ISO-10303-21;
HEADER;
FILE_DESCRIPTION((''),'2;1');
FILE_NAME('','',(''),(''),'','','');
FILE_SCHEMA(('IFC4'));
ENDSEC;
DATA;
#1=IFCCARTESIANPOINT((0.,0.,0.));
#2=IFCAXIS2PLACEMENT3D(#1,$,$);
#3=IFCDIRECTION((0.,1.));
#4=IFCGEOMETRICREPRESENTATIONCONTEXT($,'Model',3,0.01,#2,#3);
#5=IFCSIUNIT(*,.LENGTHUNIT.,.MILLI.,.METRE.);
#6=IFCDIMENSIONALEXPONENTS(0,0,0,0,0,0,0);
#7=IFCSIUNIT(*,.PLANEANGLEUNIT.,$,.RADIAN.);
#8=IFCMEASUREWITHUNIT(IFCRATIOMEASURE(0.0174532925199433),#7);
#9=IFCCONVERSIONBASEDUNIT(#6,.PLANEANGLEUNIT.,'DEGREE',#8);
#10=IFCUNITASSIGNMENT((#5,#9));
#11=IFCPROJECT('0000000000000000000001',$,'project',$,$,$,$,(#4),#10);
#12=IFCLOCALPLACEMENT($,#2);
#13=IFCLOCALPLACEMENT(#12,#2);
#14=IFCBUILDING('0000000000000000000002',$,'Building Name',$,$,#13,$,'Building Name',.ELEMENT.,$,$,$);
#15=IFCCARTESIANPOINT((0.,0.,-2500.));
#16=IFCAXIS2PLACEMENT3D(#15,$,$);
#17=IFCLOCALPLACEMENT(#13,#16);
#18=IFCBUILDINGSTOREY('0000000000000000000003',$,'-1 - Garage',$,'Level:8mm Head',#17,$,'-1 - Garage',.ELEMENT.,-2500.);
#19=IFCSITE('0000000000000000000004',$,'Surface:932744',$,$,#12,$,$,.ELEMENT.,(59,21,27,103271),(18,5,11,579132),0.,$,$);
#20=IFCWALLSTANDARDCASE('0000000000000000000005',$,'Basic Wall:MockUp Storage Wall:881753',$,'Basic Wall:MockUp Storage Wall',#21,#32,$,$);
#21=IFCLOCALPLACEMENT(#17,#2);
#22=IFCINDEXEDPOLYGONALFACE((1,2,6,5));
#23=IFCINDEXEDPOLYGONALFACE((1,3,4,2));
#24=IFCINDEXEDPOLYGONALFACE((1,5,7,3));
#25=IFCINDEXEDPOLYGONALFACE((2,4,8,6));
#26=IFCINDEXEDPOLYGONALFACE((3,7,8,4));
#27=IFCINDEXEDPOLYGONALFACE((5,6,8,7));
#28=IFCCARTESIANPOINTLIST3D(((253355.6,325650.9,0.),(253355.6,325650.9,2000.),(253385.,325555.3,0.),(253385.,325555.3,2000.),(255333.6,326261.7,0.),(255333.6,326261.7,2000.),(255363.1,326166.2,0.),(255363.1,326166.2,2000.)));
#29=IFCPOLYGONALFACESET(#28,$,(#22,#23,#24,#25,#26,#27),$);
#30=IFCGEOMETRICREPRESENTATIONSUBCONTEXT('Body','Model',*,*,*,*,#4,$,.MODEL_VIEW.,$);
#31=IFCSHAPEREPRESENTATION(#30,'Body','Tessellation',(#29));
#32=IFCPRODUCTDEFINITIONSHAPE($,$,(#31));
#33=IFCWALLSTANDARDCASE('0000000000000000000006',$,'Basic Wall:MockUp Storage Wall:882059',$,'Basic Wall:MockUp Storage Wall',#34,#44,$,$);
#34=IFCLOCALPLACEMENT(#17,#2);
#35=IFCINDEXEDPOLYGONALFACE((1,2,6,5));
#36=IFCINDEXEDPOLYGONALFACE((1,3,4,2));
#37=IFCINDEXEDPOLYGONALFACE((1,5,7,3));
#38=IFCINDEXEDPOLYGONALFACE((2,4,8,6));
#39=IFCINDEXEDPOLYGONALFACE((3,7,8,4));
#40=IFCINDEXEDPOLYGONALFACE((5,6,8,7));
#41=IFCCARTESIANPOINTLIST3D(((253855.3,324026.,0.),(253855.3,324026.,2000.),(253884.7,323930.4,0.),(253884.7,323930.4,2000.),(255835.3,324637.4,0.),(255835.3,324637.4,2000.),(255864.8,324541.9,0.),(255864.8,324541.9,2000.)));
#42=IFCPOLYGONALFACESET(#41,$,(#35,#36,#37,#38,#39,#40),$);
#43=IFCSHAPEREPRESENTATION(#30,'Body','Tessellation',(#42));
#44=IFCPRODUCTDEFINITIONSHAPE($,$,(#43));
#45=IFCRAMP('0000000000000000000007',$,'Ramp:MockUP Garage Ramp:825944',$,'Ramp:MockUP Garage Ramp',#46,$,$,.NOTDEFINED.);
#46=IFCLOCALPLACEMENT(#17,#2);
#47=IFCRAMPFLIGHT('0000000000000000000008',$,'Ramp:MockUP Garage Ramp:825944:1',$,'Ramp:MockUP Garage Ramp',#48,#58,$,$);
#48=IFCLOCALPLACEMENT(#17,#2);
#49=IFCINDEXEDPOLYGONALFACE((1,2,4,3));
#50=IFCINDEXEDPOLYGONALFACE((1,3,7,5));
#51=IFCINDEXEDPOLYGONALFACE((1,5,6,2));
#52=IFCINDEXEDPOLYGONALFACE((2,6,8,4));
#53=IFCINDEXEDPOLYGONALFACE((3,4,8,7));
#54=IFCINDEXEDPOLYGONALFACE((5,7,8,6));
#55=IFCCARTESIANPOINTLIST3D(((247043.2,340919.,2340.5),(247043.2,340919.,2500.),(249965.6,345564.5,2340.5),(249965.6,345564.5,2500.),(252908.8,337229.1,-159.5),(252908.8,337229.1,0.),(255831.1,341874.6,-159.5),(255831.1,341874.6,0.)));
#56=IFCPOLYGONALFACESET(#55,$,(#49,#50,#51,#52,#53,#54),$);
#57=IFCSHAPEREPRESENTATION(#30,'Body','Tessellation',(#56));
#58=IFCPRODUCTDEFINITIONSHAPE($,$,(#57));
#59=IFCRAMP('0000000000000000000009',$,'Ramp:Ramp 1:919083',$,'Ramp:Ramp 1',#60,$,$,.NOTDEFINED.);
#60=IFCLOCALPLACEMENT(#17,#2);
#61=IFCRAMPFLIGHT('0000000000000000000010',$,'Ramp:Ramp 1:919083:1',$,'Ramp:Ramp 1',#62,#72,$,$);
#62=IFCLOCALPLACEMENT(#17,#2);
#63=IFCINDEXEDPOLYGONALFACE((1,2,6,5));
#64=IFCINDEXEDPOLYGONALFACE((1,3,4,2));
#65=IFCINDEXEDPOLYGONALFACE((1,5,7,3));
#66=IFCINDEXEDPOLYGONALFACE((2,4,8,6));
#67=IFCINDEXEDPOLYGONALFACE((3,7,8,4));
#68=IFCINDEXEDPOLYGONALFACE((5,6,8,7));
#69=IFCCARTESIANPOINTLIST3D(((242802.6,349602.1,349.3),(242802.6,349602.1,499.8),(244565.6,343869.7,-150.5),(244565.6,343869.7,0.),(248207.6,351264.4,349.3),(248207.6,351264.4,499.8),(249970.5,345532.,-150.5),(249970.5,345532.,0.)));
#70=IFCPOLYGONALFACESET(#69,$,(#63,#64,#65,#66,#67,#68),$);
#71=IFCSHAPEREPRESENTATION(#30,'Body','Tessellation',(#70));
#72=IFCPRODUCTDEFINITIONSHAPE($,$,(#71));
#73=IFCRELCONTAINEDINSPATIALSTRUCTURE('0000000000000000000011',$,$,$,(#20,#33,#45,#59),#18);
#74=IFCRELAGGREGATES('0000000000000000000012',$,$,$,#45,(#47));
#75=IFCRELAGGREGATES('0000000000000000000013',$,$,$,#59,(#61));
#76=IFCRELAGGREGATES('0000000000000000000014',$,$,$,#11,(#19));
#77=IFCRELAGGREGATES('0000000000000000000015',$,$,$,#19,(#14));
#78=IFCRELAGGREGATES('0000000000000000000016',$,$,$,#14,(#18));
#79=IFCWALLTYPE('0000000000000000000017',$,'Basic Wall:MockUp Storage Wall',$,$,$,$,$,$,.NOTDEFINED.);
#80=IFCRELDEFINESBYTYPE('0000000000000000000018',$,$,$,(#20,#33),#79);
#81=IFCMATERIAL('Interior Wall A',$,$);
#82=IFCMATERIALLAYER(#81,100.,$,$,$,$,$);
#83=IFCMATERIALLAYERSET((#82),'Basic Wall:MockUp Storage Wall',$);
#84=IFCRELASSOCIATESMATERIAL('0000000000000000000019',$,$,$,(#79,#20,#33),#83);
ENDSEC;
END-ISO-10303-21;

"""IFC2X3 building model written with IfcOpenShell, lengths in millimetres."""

from ifc_helpers import new_model, entity, si_unit, converted_unit, direction, frame, origin, place, context, subcontext, project, spatial, polyline, outline, extrude, material, layer, layer_set, layer_usage, type_object, element, aggregate, save


model = new_model("IFC2X3")

# Units and contexts
model_context = context("Model", 3, precision=0.01, world=origin(), true_north=direction((0.0, 1.0)))
body_context = subcontext(model_context, "Body", "Model", "MODEL_VIEW")
ifc_project = project(units=[si_unit("LENGTHUNIT", "METRE", prefix="MILLI"), converted_unit("PLANEANGLEUNIT", "DEGREE", entity("IfcRatioMeasure", 0.0174532925199433), si_unit("PLANEANGLEUNIT", "RADIAN"), dimensions=[0, 0, 0, 0, 0, 0, 0])], contexts=[model_context])

# Site, building, storey
site_placement = place(None, origin())
site = spatial("IfcSite", under=ifc_project, at=site_placement, Name="Surface:932744", CompositionType="ELEMENT", RefLatitude=(59, 21, 27, 103271), RefLongitude=(18, 5, 11, 579132), RefElevation=0.0)
building_placement = place(site_placement, origin())
building = spatial("IfcBuilding", under=site, at=building_placement, Name="Building Name", LongName="Building Name", CompositionType="ELEMENT")
storey_placement = place(building_placement, frame((0.0, 0.0, -2500.0)))
storey = spatial("IfcBuildingStorey", under=building, at=storey_placement, Name="-1 - Garage", ObjectType="Level:8mm Head", LongName="-1 - Garage", CompositionType="ELEMENT", Elevation=-2500.0)

# Walls
ifc_material_1 = material(Name="Interior Wall A")
ifc_layer_1 = layer(ifc_material_1, 100.0)
ifc_layer_set_1 = layer_set([ifc_layer_1], Name="Basic Wall:MockUp Storage Wall")
wall_type_1 = type_object("IfcWallType", Name="Basic Wall:MockUp Storage Wall", PredefinedType="NOTDEFINED", material=ifc_layer_set_1)
ifc_layer_usage_1 = layer_usage(ifc_layer_set_1, "AXIS2", "NEGATIVE", 50.0)
wall_1_placement = place(storey_placement, frame((253370.2, 325603.0, 0.0), z_axis=(0.0, 0.0, 1.0), x_axis=(0.955473, 0.29508, 0.0)))
element("IfcWallStandardCase", 1, at=wall_1_placement, inside=storey, type_object=wall_type_1, material=ifc_layer_usage_1, Name="Basic Wall:MockUp Storage Wall:881753", ObjectType="Basic Wall:MockUp Storage Wall", context=body_context, shape_type="SweptSolid", body=[
    extrude(outline(polyline([(2070.3, -50.0), (2070.3, 50.0), (0.1, 50.0), (0.0, -50.0), (2070.3, -50.0)])), origin(), (0.0, 0.0, 1.0), 2000.0),
])
ifc_layer_usage_2 = layer_usage(ifc_layer_set_1, "AXIS2", "NEGATIVE", 50.0)
wall_2_placement = place(storey_placement, frame((253870.0, 323978.2, 0.0), z_axis=(0.0, 0.0, 1.0), x_axis=(0.955473, 0.29508, 0.0)))
element("IfcWallStandardCase", 2, at=wall_2_placement, inside=storey, type_object=wall_type_1, material=ifc_layer_usage_2, Name="Basic Wall:MockUp Storage Wall:882059", ObjectType="Basic Wall:MockUp Storage Wall", context=body_context, shape_type="SweptSolid", body=[
    extrude(outline(polyline([(2072.3, -50.0), (2072.3, 50.0), (0.1, 50.0), (0.0, -50.0), (2072.3, -50.0)])), origin(), (0.0, 0.0, 1.0), 2000.0),
])

# Ramp, ramp flight
ramp_1_placement = place(storey_placement, origin())
ramp_1 = element("IfcRamp", 3, at=ramp_1_placement, inside=storey, Name="Ramp:MockUP Garage Ramp:825944", ObjectType="Ramp:MockUP Garage Ramp", ShapeType="NOTDEFINED")
ramp_flight_1_placement = place(ramp_1_placement, origin())
ramp_flight_1 = element("IfcRampFlight", 4, at=ramp_flight_1_placement, Name="Ramp:MockUP Garage Ramp:825944:1", ObjectType="Ramp:MockUP Garage Ramp", context=body_context, shape_type="SweptSolid", body=[
    extrude(outline(polyline([(1170.3, -3464.8), (1329.7, -3464.8), (-1170.3, 3464.8), (-1329.7, 3464.8), (1170.3, -3464.8)])), frame((249976.0, 339074.1, 1170.3), z_axis=(0.532477, 0.846444, 0.0), x_axis=(0.0, 0.0, -1.0)), (0.0, 0.0, 1.0), 5488.3),
])
aggregate(ramp_1, [ramp_flight_1])

# Ramp, ramp flight
ramp_2_placement = place(storey_placement, origin())
ramp_2 = element("IfcRamp", 5, at=ramp_2_placement, inside=storey, Name="Ramp:Ramp 1:919083", ObjectType="Ramp:Ramp 1", ShapeType="NOTDEFINED")
ramp_flight_2_placement = place(ramp_2_placement, origin())
ramp_flight_2 = element("IfcRampFlight", 6, at=ramp_flight_2_placement, Name="Ramp:Ramp 1:919083:1", ObjectType="Ramp:Ramp 1", context=body_context, shape_type="SweptSolid", body=[
    extrude(outline(polyline([(174.6, -2998.7), (325.2, -2998.7), (-174.6, 2998.7), (-325.2, 2998.7), (174.6, -2998.7)])), frame((243684.1, 346735.9, 174.6), z_axis=(0.955818, 0.293958, 0.0), x_axis=(0.0, 0.0, -1.0)), (0.0, 0.0, 1.0), 5654.8),
])
aggregate(ramp_2, [ramp_flight_2])

save(model, "model.ifc")
